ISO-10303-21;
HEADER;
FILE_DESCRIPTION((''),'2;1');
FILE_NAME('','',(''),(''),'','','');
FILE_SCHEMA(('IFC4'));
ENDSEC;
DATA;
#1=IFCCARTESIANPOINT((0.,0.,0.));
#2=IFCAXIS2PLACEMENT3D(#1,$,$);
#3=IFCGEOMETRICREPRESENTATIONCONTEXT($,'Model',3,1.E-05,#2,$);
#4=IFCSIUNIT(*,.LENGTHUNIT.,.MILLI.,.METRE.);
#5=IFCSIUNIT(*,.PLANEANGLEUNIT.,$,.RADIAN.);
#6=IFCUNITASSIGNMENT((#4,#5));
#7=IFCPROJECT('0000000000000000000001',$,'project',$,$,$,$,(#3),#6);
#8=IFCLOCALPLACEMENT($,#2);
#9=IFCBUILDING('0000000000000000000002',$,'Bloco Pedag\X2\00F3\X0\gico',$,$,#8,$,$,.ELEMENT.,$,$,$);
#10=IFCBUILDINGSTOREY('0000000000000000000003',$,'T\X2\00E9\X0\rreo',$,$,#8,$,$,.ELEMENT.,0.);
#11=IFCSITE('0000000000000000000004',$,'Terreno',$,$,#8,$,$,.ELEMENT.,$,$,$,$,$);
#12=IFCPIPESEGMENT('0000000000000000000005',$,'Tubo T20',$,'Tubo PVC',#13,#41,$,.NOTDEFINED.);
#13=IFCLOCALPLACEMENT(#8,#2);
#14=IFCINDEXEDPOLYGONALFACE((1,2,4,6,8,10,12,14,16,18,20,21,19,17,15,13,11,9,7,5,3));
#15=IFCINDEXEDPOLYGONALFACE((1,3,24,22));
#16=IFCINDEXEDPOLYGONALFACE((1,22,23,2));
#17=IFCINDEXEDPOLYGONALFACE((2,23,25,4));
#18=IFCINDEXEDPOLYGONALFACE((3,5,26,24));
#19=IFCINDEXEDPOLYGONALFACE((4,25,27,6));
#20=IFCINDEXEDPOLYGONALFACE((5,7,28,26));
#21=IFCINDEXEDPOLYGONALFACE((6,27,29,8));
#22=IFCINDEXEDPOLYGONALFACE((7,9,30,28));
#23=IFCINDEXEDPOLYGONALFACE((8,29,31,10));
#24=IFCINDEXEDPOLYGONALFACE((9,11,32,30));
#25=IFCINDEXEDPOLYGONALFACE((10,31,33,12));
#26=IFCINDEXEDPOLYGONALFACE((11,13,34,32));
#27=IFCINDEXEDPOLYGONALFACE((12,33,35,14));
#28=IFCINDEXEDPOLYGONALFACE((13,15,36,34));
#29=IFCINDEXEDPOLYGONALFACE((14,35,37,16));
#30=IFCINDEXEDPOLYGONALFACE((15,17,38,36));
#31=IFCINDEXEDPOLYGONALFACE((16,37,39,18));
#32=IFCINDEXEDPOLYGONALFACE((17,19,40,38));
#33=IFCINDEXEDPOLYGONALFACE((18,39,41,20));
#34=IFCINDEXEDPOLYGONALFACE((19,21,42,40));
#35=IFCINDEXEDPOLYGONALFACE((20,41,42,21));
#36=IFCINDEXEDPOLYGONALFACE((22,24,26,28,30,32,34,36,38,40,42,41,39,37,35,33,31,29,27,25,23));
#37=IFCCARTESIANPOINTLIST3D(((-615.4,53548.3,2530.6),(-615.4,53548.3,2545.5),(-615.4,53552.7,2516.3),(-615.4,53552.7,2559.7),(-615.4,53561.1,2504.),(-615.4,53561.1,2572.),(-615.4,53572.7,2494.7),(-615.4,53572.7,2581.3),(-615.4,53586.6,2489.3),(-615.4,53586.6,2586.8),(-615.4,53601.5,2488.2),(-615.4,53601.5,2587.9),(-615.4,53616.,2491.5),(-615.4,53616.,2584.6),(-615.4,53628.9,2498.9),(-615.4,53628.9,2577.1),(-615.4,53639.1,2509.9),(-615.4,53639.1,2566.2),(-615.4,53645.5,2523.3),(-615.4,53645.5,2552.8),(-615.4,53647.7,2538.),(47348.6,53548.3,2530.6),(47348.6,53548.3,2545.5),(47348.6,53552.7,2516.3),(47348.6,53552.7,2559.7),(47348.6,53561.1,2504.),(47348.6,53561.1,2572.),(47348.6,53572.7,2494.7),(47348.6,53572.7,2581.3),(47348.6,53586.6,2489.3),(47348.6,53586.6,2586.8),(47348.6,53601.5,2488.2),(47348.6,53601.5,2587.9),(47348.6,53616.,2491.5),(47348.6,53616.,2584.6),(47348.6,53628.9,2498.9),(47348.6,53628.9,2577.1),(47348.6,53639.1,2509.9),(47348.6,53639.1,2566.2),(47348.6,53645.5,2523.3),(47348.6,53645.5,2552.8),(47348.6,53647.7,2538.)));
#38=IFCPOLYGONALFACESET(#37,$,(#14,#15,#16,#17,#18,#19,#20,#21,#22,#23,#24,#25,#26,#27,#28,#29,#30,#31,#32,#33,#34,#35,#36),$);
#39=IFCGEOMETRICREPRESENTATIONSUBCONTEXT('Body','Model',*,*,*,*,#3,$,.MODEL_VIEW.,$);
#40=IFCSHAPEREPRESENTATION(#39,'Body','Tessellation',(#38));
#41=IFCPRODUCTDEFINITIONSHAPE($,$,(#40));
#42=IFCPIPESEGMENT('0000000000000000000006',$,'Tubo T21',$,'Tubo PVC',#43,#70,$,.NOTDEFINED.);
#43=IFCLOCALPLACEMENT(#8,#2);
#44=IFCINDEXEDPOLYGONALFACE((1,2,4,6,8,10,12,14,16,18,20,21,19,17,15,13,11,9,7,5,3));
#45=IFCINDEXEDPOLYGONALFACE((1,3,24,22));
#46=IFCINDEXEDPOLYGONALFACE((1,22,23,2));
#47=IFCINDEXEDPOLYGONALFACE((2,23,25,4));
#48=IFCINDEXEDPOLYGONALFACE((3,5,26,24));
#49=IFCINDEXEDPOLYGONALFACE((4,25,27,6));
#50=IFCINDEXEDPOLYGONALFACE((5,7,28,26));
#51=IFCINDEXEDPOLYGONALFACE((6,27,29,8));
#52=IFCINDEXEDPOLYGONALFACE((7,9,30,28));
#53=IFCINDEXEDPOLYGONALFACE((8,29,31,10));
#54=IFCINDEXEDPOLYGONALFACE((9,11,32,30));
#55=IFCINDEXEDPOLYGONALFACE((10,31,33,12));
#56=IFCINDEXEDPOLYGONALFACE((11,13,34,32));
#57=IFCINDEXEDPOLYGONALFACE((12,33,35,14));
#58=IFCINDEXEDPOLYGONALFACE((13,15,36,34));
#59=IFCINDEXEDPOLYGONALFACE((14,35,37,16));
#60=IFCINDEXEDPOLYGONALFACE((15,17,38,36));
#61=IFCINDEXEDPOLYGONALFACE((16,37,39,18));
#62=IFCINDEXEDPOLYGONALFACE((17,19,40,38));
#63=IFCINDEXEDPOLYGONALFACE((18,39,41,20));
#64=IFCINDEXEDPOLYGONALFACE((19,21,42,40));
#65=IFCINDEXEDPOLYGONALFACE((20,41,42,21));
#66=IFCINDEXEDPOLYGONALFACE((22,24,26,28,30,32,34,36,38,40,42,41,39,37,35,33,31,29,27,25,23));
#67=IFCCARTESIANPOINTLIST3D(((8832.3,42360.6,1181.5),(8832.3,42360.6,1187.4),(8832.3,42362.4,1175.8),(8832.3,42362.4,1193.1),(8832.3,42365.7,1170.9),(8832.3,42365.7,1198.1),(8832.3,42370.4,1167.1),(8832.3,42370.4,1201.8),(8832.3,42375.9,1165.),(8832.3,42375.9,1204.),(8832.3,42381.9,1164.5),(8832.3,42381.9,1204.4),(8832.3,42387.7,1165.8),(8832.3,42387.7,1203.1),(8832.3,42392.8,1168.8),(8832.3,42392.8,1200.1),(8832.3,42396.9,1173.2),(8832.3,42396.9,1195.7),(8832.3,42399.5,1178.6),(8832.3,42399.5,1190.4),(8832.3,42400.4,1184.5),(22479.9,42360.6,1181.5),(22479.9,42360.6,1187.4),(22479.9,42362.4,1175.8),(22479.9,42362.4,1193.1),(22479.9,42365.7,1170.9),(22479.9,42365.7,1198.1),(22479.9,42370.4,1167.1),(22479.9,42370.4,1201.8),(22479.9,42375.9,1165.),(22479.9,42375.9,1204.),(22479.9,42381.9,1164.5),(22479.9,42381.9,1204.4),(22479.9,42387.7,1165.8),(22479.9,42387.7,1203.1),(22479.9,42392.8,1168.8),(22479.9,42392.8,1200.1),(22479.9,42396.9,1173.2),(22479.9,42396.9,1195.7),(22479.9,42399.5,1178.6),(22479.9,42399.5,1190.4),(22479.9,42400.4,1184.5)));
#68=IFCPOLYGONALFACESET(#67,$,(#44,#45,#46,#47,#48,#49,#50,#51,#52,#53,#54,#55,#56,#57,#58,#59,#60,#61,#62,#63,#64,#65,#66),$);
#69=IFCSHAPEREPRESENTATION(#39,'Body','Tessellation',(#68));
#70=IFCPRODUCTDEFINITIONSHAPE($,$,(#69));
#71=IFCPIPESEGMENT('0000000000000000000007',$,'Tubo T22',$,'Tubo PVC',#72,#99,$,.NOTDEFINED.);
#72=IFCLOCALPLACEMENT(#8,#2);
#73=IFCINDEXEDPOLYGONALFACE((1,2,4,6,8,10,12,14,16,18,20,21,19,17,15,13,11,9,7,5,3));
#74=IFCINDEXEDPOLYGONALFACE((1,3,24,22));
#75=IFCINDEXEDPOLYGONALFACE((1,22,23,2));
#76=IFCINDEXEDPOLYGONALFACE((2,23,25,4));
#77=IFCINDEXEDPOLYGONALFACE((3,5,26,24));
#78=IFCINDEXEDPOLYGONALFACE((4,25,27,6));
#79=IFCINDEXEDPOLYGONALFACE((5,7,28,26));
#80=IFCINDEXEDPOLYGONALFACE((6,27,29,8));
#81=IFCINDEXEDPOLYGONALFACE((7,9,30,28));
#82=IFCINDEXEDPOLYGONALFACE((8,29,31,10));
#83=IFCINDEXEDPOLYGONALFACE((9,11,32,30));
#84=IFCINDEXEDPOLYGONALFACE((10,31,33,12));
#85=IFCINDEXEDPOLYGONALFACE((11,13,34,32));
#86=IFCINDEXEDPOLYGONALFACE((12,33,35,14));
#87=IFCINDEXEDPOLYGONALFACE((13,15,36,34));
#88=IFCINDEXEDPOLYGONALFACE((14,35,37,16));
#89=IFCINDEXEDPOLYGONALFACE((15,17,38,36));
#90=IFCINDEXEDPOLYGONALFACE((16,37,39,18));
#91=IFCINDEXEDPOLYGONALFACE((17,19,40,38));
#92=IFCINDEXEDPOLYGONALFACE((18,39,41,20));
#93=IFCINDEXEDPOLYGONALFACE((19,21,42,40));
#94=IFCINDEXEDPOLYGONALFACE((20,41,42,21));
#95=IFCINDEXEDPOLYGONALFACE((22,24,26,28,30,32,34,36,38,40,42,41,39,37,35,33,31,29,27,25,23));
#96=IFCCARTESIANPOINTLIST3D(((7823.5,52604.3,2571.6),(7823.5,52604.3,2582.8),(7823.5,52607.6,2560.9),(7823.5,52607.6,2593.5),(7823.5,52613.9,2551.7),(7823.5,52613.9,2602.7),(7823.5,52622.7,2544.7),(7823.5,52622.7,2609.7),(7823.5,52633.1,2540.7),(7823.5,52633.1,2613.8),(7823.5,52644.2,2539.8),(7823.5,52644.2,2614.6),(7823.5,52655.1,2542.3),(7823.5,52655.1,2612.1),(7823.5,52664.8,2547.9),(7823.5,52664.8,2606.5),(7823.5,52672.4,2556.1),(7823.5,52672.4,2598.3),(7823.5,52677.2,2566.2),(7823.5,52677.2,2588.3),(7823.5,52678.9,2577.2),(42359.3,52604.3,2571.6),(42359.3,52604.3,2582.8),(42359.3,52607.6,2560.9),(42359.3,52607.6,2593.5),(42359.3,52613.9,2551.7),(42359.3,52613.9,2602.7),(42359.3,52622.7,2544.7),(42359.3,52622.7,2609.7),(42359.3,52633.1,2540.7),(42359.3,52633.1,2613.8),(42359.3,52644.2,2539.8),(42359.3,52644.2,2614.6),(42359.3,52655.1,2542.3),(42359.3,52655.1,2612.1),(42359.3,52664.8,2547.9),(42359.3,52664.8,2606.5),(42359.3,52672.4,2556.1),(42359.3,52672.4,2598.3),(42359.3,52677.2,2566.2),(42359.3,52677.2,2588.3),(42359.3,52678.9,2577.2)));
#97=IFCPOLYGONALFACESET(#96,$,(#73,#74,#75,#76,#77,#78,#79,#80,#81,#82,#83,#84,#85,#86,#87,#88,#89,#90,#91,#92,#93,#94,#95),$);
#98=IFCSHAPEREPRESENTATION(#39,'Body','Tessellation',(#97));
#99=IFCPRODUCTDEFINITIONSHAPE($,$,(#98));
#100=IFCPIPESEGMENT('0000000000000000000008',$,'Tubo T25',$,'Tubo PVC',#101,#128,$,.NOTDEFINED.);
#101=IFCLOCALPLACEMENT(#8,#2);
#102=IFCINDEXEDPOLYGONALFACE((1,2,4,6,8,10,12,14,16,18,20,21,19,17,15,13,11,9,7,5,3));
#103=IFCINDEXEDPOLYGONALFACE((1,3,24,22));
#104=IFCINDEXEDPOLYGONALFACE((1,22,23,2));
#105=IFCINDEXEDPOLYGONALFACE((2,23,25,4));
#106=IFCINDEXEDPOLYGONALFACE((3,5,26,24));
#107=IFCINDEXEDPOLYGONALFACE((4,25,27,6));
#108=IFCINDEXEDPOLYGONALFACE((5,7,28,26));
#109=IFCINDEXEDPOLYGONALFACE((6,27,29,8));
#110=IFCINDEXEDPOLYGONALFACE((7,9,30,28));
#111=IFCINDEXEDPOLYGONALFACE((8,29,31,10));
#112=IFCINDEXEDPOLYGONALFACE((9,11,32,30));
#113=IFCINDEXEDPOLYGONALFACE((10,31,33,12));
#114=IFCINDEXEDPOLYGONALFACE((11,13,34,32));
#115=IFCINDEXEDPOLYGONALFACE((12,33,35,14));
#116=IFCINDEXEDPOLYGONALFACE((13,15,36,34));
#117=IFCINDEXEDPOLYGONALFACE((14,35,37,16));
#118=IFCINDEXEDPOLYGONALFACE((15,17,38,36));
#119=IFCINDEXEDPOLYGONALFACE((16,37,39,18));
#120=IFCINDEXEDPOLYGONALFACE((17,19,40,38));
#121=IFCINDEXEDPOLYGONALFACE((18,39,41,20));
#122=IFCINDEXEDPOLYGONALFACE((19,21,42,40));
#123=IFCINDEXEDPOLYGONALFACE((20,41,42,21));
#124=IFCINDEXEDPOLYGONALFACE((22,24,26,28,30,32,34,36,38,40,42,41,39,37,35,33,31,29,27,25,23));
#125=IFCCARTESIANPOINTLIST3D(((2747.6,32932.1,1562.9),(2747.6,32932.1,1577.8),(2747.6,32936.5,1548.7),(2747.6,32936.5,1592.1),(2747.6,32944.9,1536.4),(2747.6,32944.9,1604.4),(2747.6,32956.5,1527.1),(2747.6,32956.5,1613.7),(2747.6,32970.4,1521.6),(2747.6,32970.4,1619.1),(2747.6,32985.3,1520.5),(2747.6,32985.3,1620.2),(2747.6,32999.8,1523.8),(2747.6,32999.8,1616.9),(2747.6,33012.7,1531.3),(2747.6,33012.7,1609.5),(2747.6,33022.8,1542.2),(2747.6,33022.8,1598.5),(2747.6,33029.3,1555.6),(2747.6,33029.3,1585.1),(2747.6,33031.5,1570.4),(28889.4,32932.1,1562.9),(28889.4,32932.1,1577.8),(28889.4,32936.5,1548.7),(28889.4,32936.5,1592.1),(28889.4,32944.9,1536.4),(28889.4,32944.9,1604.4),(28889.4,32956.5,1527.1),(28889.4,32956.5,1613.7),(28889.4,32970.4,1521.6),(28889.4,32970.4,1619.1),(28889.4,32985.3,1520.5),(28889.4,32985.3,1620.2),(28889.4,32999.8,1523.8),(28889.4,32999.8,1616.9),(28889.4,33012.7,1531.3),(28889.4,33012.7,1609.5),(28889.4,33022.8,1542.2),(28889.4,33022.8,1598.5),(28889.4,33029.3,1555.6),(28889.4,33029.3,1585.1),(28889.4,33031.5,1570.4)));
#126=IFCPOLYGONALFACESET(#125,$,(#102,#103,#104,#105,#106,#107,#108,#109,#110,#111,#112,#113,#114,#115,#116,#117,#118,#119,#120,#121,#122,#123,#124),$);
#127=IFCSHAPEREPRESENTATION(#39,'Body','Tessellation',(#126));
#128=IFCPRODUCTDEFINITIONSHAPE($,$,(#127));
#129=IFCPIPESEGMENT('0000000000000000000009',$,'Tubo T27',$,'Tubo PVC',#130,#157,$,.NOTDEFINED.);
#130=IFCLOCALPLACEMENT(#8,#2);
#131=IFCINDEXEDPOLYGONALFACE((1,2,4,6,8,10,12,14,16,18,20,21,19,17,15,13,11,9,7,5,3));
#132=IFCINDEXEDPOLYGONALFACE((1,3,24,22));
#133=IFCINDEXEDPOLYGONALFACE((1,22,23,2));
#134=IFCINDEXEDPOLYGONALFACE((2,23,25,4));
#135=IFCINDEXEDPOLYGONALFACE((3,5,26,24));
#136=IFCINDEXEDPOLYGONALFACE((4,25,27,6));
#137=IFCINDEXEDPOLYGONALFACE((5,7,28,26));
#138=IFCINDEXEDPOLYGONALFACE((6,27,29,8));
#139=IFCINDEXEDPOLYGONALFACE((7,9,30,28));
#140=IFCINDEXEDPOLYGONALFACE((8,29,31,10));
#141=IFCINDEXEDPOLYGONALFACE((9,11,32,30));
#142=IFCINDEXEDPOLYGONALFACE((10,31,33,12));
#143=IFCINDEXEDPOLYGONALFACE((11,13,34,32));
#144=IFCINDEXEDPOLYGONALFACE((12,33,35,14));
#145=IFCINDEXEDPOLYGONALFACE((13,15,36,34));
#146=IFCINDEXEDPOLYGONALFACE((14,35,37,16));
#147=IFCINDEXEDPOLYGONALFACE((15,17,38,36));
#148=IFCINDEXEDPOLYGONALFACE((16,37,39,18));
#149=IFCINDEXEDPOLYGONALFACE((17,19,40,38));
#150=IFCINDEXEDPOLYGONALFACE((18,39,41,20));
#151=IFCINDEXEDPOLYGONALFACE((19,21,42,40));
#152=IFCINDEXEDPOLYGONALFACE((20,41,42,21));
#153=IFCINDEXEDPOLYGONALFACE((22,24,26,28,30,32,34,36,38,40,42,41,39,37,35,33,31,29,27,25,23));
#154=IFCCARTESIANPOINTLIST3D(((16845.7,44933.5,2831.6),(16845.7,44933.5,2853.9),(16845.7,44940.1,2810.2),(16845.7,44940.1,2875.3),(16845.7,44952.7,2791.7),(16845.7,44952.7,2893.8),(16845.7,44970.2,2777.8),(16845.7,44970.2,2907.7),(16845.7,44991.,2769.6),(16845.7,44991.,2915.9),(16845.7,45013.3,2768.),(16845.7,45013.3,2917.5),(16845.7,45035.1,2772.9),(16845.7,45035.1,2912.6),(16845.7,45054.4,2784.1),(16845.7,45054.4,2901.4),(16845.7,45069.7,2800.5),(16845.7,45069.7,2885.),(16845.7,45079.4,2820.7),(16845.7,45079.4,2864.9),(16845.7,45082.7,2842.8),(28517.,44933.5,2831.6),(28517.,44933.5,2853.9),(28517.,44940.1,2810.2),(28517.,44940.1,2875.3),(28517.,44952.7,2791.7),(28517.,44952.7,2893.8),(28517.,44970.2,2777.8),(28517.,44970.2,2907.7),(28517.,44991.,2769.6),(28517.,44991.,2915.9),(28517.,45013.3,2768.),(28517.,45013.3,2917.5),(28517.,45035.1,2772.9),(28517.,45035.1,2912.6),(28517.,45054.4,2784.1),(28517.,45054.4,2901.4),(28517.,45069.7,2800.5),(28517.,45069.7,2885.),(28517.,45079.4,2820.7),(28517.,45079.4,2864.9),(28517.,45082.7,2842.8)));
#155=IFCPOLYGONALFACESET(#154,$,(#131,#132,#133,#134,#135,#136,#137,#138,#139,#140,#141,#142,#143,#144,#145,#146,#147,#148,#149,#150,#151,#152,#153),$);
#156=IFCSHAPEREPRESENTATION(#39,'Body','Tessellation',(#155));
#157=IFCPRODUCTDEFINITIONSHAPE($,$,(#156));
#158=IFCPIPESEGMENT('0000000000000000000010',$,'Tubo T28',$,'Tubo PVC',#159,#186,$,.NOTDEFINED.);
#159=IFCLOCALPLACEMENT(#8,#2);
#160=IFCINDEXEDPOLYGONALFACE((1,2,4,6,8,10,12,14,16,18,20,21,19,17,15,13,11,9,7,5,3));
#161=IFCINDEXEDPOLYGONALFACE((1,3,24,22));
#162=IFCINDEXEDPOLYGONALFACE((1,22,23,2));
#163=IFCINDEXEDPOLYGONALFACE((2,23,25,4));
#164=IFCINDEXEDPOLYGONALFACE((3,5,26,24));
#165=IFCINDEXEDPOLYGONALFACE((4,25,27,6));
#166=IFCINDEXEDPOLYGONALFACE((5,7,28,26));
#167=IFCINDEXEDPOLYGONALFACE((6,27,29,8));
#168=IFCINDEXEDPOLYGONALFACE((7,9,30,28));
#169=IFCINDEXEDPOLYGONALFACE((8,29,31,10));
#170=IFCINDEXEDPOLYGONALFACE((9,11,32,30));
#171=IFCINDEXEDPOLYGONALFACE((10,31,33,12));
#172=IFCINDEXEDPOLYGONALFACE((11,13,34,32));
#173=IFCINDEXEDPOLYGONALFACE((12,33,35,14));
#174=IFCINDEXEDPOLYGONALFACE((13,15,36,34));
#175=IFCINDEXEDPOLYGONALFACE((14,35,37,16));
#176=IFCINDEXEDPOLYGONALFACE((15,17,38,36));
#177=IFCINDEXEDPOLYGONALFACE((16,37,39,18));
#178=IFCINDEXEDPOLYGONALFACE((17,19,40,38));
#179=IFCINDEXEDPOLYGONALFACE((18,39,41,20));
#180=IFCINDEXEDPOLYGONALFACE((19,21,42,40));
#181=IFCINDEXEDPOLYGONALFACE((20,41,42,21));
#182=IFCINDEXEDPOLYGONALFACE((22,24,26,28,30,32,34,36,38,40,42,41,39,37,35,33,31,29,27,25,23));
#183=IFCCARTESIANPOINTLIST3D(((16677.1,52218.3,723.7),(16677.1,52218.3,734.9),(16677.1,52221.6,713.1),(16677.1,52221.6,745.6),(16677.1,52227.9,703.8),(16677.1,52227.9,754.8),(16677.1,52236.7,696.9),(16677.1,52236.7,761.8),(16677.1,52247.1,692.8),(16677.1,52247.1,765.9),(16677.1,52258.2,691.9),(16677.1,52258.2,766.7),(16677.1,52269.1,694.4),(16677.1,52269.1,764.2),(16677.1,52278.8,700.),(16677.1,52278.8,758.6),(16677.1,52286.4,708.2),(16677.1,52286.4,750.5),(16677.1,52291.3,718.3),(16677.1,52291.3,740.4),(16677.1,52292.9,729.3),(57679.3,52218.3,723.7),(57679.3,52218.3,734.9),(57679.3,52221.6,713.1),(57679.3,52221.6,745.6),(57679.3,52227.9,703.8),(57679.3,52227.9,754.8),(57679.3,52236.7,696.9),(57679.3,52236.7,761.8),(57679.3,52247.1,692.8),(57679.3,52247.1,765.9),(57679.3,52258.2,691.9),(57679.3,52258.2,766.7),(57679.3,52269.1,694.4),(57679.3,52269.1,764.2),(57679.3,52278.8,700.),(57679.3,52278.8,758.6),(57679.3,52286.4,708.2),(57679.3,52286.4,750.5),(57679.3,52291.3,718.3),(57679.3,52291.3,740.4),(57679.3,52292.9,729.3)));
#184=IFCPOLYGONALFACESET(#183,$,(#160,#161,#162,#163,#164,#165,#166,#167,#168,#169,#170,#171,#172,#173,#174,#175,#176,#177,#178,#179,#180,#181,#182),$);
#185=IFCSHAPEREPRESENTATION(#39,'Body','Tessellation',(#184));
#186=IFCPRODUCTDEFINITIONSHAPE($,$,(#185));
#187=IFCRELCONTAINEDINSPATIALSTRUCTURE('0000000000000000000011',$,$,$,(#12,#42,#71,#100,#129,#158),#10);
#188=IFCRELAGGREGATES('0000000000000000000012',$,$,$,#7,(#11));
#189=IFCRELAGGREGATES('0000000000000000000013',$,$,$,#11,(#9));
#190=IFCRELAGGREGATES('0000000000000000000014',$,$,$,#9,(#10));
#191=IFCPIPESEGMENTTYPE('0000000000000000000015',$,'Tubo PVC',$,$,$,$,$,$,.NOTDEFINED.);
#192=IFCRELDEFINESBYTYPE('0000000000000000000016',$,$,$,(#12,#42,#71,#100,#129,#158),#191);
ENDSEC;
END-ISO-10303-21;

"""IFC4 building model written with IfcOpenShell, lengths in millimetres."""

from ifc_helpers import new_model, si_unit, frame, origin, origin_2d, place, context, subcontext, project, spatial, circle, extrude, type_object, element, save


model = new_model("IFC4")

# Units and contexts
model_context = context("Model", 3, precision=1e-05, world=origin())
body_context = subcontext(model_context, "Body", "Model", "MODEL_VIEW")
ifc_project = project(units=[si_unit("LENGTHUNIT", "METRE", prefix="MILLI"), si_unit("PLANEANGLEUNIT", "RADIAN")], contexts=[model_context])

# Site, building, storey
placement = place(None, origin())
site = spatial("IfcSite", under=ifc_project, at=placement, Name="Terreno", CompositionType="ELEMENT")
building = spatial("IfcBuilding", under=site, at=placement, Name="Bloco Pedagógico", CompositionType="ELEMENT")
storey = spatial("IfcBuildingStorey", under=building, at=placement, Name="Térreo", CompositionType="ELEMENT", Elevation=0.0)

# Pipe segments
pipe_segment_type = type_object("IfcPipeSegmentType", Name="Tubo PVC", PredefinedType="NOTDEFINED")
pipe_segment_1_placement = place(None, frame((-615.4, 53597.7, 2538.0), z_axis=(1.0, 0.0, 0.0), x_axis=(0.0, 1.0, 0.0)))
element("IfcPipeSegment", 1, at=pipe_segment_1_placement, inside=storey, type_object=pipe_segment_type, Name="Tubo T20", ObjectType="Tubo PVC", PredefinedType="NOTDEFINED", context=body_context, shape_type="SweptSolid", body=[
    extrude(circle(Radius=50.0, at=origin_2d()), None, (0.0, 0.0, 1.0), 47964.0),
])
pipe_segment_2_placement = place(None, frame((8832.3, 42380.4, 1184.5), z_axis=(1.0, 0.0, 0.0), x_axis=(0.0, 1.0, 0.0)))
element("IfcPipeSegment", 2, at=pipe_segment_2_placement, inside=storey, type_object=pipe_segment_type, Name="Tubo T21", ObjectType="Tubo PVC", PredefinedType="NOTDEFINED", context=body_context, shape_type="SweptSolid", body=[
    extrude(circle(Radius=20.0, at=origin_2d()), None, (0.0, 0.0, 1.0), 13647.6),
])
pipe_segment_3_placement = place(None, frame((7823.5, 52641.4, 2577.2), z_axis=(1.0, 0.0, 0.0), x_axis=(0.0, 1.0, 0.0)))
element("IfcPipeSegment", 3, at=pipe_segment_3_placement, inside=storey, type_object=pipe_segment_type, Name="Tubo T22", ObjectType="Tubo PVC", PredefinedType="NOTDEFINED", context=body_context, shape_type="SweptSolid", body=[
    extrude(circle(Radius=37.5, at=origin_2d()), None, (0.0, 0.0, 1.0), 34535.8),
])
pipe_segment_4_placement = place(None, frame((2747.6, 32981.5, 1570.4), z_axis=(1.0, 0.0, 0.0), x_axis=(0.0, 1.0, 0.0)))
element("IfcPipeSegment", 4, at=pipe_segment_4_placement, inside=storey, type_object=pipe_segment_type, Name="Tubo T25", ObjectType="Tubo PVC", PredefinedType="NOTDEFINED", context=body_context, shape_type="SweptSolid", body=[
    extrude(circle(Radius=50.0, at=origin_2d()), None, (0.0, 0.0, 1.0), 26141.8),
])
pipe_segment_5_placement = place(None, frame((16845.7, 45007.7, 2842.8), z_axis=(1.0, 0.0, 0.0), x_axis=(0.0, 1.0, 0.0)))
element("IfcPipeSegment", 5, at=pipe_segment_5_placement, inside=storey, type_object=pipe_segment_type, Name="Tubo T27", ObjectType="Tubo PVC", PredefinedType="NOTDEFINED", context=body_context, shape_type="SweptSolid", body=[
    extrude(circle(Radius=75.0, at=origin_2d()), None, (0.0, 0.0, 1.0), 11671.4),
])
pipe_segment_6_placement = place(None, frame((16677.1, 52255.4, 729.3), z_axis=(1.0, 0.0, 0.0), x_axis=(0.0, 1.0, 0.0)))
element("IfcPipeSegment", 6, at=pipe_segment_6_placement, inside=storey, type_object=pipe_segment_type, Name="Tubo T28", ObjectType="Tubo PVC", PredefinedType="NOTDEFINED", context=body_context, shape_type="SweptSolid", body=[
    extrude(circle(Radius=37.5, at=origin_2d()), None, (0.0, 0.0, 1.0), 41002.2),
])

save(model, "model.ifc")
